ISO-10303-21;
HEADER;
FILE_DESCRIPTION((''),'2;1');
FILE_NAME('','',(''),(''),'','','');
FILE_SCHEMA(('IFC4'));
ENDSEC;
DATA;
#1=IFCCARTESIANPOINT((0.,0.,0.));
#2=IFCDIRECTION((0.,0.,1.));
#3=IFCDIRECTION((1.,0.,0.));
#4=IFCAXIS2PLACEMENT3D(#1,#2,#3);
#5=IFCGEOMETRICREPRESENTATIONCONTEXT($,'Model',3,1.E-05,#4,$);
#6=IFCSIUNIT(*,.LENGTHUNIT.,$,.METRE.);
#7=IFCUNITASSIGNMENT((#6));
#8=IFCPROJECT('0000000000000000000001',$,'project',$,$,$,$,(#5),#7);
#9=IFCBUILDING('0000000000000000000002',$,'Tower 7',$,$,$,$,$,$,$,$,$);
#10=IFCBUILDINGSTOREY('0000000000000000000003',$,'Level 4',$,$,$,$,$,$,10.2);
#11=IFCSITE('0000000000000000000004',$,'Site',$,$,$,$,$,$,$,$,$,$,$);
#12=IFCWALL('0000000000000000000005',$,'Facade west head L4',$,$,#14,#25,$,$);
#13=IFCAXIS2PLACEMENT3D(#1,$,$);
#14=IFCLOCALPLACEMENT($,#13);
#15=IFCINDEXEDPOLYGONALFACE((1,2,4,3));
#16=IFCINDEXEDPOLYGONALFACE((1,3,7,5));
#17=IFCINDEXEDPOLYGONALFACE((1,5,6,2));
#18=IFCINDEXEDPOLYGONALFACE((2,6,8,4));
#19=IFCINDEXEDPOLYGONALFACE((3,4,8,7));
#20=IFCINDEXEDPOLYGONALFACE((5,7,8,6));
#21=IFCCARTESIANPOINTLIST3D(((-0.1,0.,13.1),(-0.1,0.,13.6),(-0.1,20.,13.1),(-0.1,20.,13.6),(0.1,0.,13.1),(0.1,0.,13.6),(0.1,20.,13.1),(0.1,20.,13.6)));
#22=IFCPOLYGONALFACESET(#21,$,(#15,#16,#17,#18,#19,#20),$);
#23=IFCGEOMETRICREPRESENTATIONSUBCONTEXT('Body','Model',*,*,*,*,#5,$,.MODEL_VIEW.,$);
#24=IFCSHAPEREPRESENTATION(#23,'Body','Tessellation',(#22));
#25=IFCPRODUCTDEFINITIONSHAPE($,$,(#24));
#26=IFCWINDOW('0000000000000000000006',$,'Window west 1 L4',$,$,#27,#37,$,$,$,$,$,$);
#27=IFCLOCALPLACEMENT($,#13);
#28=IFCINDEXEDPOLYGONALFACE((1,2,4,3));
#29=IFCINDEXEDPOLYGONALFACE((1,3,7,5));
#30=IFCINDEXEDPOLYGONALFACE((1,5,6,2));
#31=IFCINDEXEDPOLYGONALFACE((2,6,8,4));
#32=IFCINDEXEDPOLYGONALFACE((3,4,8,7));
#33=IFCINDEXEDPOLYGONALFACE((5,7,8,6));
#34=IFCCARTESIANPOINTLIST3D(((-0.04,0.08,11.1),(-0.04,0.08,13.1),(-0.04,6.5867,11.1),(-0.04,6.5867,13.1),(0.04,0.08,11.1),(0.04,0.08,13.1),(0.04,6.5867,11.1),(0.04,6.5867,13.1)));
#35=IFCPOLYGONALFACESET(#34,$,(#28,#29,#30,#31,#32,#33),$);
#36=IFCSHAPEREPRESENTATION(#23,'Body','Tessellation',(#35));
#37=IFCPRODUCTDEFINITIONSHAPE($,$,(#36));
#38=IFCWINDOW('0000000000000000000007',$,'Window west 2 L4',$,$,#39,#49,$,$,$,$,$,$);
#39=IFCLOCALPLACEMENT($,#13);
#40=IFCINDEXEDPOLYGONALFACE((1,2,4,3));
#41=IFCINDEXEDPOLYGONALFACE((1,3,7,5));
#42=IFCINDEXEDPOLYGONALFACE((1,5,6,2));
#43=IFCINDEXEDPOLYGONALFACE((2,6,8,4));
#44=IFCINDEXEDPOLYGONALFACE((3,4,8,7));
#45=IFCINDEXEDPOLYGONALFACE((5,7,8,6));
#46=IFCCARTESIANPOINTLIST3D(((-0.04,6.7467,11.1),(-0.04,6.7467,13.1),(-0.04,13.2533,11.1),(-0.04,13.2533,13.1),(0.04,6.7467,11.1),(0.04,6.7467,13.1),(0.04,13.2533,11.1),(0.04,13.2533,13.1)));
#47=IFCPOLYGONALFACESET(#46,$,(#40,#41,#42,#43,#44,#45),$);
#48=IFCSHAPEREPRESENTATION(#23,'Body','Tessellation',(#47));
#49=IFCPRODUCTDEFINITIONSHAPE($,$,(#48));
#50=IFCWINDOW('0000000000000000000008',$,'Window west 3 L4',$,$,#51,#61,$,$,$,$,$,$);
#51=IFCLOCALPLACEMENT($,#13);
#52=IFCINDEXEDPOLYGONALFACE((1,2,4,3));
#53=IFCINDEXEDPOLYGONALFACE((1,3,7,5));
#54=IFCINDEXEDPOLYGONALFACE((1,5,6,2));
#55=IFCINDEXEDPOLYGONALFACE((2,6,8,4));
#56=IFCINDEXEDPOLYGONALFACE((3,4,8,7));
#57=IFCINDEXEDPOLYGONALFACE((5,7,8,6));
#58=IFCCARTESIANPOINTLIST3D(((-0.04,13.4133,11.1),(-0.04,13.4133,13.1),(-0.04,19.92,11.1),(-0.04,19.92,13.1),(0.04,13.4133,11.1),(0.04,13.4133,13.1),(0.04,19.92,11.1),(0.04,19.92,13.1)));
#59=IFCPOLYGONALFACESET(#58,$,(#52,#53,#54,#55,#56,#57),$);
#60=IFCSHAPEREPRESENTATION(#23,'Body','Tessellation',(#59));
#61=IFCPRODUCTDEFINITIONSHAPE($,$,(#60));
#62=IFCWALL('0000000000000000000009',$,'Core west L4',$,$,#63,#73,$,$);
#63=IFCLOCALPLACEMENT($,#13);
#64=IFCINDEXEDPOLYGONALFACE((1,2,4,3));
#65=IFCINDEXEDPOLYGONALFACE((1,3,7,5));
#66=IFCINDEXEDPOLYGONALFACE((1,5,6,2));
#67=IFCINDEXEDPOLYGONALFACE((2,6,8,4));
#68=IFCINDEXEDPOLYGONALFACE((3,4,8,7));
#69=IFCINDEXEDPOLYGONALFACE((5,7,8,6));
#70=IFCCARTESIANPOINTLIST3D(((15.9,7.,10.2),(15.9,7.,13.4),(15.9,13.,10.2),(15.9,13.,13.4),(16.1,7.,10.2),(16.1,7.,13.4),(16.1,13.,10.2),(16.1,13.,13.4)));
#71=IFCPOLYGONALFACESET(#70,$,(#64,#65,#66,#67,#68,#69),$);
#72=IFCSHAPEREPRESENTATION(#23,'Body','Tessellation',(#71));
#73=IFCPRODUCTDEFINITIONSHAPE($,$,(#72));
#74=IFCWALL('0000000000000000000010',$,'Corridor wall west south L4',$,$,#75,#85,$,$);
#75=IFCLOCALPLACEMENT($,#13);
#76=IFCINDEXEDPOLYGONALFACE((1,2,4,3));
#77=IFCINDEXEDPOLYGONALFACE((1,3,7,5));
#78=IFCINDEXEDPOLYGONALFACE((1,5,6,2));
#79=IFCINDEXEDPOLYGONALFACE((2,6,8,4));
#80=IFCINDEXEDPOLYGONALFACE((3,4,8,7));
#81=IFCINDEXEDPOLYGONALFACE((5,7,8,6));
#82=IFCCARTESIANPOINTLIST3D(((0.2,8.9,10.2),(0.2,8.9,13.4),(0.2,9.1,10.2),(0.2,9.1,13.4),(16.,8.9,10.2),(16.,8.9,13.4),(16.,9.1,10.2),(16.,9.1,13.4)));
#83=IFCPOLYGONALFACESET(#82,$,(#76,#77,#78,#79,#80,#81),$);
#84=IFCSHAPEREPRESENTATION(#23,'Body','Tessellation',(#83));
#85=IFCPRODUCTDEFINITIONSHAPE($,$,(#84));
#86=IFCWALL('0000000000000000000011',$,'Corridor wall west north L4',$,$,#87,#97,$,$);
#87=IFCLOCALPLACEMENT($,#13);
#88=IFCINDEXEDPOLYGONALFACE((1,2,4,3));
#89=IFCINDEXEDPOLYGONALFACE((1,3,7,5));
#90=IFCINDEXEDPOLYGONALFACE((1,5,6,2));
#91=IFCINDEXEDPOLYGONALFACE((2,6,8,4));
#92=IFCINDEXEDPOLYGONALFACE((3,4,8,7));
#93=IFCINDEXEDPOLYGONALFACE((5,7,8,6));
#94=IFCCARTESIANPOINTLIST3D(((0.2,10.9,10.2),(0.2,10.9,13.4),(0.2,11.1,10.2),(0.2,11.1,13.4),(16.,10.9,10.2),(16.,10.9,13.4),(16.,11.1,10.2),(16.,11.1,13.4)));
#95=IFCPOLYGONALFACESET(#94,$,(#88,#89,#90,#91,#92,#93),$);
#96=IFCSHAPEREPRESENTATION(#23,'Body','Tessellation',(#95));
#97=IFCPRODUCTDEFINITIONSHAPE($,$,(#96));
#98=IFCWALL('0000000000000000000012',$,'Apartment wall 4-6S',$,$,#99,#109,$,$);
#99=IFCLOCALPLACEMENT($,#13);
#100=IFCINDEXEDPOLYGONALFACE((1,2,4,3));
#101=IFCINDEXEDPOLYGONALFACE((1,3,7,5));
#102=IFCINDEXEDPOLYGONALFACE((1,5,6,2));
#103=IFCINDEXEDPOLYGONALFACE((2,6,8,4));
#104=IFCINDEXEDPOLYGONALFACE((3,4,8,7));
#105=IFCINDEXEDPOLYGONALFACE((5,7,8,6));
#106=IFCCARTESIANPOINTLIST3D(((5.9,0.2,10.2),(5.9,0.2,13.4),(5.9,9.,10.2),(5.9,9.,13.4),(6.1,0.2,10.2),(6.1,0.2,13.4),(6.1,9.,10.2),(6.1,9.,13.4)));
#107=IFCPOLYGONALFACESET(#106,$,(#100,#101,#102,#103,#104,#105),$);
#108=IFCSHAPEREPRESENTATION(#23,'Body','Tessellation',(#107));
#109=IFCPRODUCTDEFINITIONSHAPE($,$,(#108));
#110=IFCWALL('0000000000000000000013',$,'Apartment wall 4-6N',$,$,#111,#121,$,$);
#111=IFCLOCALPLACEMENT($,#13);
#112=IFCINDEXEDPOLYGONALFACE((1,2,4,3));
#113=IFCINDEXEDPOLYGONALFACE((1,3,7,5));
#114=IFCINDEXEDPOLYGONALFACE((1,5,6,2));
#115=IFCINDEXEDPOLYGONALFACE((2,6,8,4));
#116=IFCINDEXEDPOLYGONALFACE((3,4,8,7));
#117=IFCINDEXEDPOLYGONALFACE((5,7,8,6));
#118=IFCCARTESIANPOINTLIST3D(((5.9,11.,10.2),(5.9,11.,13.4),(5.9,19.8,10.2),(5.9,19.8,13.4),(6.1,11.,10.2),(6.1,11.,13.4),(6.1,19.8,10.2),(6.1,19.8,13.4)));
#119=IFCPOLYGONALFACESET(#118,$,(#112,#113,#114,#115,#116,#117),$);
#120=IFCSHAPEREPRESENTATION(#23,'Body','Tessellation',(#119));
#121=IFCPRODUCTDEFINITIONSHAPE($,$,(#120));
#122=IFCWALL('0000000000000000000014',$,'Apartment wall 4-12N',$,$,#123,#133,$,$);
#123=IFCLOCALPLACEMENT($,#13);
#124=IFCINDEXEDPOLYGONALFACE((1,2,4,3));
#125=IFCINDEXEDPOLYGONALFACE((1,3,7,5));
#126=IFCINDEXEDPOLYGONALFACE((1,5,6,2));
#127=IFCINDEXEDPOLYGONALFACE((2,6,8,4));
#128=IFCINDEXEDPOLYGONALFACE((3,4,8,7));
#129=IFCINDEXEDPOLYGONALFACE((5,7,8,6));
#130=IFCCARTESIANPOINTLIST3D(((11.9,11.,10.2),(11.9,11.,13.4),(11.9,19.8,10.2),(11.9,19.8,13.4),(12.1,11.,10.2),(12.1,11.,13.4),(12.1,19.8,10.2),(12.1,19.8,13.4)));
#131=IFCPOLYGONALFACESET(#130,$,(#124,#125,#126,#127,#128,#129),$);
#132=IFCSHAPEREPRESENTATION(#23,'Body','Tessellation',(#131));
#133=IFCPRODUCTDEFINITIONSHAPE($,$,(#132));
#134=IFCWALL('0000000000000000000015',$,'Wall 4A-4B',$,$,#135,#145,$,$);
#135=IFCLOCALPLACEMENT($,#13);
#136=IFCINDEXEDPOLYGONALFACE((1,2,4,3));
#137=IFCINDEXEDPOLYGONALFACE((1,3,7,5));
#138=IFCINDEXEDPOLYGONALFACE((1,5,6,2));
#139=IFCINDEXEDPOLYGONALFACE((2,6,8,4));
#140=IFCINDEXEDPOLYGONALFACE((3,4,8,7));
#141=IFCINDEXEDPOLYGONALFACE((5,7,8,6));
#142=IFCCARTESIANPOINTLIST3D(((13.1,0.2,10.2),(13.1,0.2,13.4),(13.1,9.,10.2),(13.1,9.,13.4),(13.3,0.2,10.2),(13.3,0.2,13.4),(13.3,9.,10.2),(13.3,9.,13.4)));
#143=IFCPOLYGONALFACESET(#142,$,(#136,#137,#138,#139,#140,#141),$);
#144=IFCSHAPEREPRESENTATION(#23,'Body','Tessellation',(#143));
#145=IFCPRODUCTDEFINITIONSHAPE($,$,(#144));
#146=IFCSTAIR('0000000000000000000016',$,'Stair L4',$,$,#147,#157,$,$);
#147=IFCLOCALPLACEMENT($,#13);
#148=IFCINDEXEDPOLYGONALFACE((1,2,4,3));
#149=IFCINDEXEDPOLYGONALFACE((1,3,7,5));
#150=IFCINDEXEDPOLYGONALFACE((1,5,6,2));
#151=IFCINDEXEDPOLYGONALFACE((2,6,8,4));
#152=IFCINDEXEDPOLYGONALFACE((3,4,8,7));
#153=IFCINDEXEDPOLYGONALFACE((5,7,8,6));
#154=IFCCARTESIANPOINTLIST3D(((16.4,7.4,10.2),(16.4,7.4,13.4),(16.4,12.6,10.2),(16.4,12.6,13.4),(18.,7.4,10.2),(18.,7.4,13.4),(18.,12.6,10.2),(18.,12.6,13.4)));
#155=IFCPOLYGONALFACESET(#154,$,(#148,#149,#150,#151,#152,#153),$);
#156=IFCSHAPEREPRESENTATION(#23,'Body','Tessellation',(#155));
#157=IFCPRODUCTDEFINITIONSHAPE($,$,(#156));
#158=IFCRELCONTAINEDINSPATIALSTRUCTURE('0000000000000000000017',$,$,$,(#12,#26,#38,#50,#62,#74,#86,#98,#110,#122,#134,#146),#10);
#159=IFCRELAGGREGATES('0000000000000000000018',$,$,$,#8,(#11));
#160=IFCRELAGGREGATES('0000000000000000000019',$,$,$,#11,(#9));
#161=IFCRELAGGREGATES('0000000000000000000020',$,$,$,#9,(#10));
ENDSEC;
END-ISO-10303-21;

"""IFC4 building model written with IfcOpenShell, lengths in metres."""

from ifc_helpers import new_model, si_unit, frame, origin, origin_with_axes, origin_2d, place, context, subcontext, project, spatial, rectangle, extrude, element, save


model = new_model("IFC4")

# Units and contexts
model_context = context("Model", 3, precision=1e-05, world=origin_with_axes())
body_context = subcontext(model_context, "Body", "Model", "MODEL_VIEW")
ifc_project = project(units=[si_unit("LENGTHUNIT", "METRE")], contexts=[model_context])

# Site, building, storey
site = spatial("IfcSite", under=ifc_project, Name="Site")
building = spatial("IfcBuilding", under=site, Name="Tower 7")
storey = spatial("IfcBuildingStorey", under=building, Name="Level 4", Elevation=10.2)

# Wall
wall_1_placement = place(None, frame((0.0, 10.0, 13.1), z_axis=(0.0, 0.0, 1.0), x_axis=(1.0, 0.0, 0.0)))
element("IfcWall", 1, at=wall_1_placement, inside=storey, Name="Facade west head L4", context=body_context, shape_type="SweptSolid", body=[
    extrude(rectangle(XDim=0.2, YDim=20.0, at=origin_2d()), origin(), (0.0, 0.0, 1.0), 0.5),
])

# Windows
for number, where, z_axis, x_axis, name in (
    (2, (0.0, 3.3333, 11.1), (0.0, 0.0, 1.0), (1.0, 0.0, 0.0), "Window west 1 L4"),
    (3, (0.0, 10.0, 11.1), (0.0, 0.0, 1.0), (1.0, 0.0, 0.0), "Window west 2 L4"),
):
    element("IfcWindow", number, at=place(None, frame(where, z_axis=z_axis, x_axis=x_axis)), inside=storey, Name=name, context=body_context, shape_type="SweptSolid", body=[
        extrude(rectangle(XDim=0.08, YDim=6.5067, at=origin_2d()), origin(), (0.0, 0.0, 1.0), 2.0),
    ])
window_1_placement = place(None, frame((0.0, 16.6667, 11.1), z_axis=(0.0, 0.0, 1.0), x_axis=(1.0, 0.0, 0.0)))
element("IfcWindow", 4, at=window_1_placement, inside=storey, Name="Window west 3 L4", context=body_context, shape_type="SweptSolid", body=[
    extrude(rectangle(XDim=0.08, YDim=6.5067, at=origin_2d()), origin(), (0.0, 0.0, 1.0), 2.0),
])

# Walls
wall_2_placement = place(None, frame((16.0, 10.0, 10.2), z_axis=(0.0, 0.0, 1.0), x_axis=(1.0, 0.0, 0.0)))
element("IfcWall", 5, at=wall_2_placement, inside=storey, Name="Core west L4", context=body_context, shape_type="SweptSolid", body=[
    extrude(rectangle(XDim=0.2, YDim=6.0, at=origin_2d()), origin(), (0.0, 0.0, 1.0), 3.2),
])
for number, where, z_axis, x_axis, name in (
    (6, (8.1, 9.0, 10.2), (0.0, 0.0, 1.0), (1.0, 0.0, 0.0), "Corridor wall west south L4"),
    (7, (8.1, 11.0, 10.2), (0.0, 0.0, 1.0), (1.0, 0.0, 0.0), "Corridor wall west north L4"),
):
    element("IfcWall", number, at=place(None, frame(where, z_axis=z_axis, x_axis=x_axis)), inside=storey, Name=name, context=body_context, shape_type="SweptSolid", body=[
        extrude(rectangle(XDim=15.8, YDim=0.2, at=origin_2d()), origin(), (0.0, 0.0, 1.0), 3.2),
    ])
for number, where, z_axis, x_axis, name in (
    (8, (6.0, 4.6, 10.2), (0.0, 0.0, 1.0), (1.0, 0.0, 0.0), "Apartment wall 4-6S"),
    (9, (6.0, 15.4, 10.2), (0.0, 0.0, 1.0), (1.0, 0.0, 0.0), "Apartment wall 4-6N"),
    (10, (12.0, 15.4, 10.2), (0.0, 0.0, 1.0), (1.0, 0.0, 0.0), "Apartment wall 4-12N"),
    (11, (13.2, 4.6, 10.2), (0.0, 0.0, 1.0), (1.0, 0.0, 0.0), "Wall 4A-4B"),
):
    element("IfcWall", number, at=place(None, frame(where, z_axis=z_axis, x_axis=x_axis)), inside=storey, Name=name, context=body_context, shape_type="SweptSolid", body=[
        extrude(rectangle(XDim=0.2, YDim=8.8, at=origin_2d()), origin(), (0.0, 0.0, 1.0), 3.2),
    ])

# Stair
stair_placement = place(None, frame((17.2, 10.0, 10.2), z_axis=(0.0, 0.0, 1.0), x_axis=(1.0, 0.0, 0.0)))
element("IfcStair", 12, at=stair_placement, inside=storey, Name="Stair L4", context=body_context, shape_type="SweptSolid", body=[
    extrude(rectangle(XDim=1.6, YDim=5.2, at=origin_2d()), origin(), (0.0, 0.0, 1.0), 3.2),
])

save(model, "model.ifc")
